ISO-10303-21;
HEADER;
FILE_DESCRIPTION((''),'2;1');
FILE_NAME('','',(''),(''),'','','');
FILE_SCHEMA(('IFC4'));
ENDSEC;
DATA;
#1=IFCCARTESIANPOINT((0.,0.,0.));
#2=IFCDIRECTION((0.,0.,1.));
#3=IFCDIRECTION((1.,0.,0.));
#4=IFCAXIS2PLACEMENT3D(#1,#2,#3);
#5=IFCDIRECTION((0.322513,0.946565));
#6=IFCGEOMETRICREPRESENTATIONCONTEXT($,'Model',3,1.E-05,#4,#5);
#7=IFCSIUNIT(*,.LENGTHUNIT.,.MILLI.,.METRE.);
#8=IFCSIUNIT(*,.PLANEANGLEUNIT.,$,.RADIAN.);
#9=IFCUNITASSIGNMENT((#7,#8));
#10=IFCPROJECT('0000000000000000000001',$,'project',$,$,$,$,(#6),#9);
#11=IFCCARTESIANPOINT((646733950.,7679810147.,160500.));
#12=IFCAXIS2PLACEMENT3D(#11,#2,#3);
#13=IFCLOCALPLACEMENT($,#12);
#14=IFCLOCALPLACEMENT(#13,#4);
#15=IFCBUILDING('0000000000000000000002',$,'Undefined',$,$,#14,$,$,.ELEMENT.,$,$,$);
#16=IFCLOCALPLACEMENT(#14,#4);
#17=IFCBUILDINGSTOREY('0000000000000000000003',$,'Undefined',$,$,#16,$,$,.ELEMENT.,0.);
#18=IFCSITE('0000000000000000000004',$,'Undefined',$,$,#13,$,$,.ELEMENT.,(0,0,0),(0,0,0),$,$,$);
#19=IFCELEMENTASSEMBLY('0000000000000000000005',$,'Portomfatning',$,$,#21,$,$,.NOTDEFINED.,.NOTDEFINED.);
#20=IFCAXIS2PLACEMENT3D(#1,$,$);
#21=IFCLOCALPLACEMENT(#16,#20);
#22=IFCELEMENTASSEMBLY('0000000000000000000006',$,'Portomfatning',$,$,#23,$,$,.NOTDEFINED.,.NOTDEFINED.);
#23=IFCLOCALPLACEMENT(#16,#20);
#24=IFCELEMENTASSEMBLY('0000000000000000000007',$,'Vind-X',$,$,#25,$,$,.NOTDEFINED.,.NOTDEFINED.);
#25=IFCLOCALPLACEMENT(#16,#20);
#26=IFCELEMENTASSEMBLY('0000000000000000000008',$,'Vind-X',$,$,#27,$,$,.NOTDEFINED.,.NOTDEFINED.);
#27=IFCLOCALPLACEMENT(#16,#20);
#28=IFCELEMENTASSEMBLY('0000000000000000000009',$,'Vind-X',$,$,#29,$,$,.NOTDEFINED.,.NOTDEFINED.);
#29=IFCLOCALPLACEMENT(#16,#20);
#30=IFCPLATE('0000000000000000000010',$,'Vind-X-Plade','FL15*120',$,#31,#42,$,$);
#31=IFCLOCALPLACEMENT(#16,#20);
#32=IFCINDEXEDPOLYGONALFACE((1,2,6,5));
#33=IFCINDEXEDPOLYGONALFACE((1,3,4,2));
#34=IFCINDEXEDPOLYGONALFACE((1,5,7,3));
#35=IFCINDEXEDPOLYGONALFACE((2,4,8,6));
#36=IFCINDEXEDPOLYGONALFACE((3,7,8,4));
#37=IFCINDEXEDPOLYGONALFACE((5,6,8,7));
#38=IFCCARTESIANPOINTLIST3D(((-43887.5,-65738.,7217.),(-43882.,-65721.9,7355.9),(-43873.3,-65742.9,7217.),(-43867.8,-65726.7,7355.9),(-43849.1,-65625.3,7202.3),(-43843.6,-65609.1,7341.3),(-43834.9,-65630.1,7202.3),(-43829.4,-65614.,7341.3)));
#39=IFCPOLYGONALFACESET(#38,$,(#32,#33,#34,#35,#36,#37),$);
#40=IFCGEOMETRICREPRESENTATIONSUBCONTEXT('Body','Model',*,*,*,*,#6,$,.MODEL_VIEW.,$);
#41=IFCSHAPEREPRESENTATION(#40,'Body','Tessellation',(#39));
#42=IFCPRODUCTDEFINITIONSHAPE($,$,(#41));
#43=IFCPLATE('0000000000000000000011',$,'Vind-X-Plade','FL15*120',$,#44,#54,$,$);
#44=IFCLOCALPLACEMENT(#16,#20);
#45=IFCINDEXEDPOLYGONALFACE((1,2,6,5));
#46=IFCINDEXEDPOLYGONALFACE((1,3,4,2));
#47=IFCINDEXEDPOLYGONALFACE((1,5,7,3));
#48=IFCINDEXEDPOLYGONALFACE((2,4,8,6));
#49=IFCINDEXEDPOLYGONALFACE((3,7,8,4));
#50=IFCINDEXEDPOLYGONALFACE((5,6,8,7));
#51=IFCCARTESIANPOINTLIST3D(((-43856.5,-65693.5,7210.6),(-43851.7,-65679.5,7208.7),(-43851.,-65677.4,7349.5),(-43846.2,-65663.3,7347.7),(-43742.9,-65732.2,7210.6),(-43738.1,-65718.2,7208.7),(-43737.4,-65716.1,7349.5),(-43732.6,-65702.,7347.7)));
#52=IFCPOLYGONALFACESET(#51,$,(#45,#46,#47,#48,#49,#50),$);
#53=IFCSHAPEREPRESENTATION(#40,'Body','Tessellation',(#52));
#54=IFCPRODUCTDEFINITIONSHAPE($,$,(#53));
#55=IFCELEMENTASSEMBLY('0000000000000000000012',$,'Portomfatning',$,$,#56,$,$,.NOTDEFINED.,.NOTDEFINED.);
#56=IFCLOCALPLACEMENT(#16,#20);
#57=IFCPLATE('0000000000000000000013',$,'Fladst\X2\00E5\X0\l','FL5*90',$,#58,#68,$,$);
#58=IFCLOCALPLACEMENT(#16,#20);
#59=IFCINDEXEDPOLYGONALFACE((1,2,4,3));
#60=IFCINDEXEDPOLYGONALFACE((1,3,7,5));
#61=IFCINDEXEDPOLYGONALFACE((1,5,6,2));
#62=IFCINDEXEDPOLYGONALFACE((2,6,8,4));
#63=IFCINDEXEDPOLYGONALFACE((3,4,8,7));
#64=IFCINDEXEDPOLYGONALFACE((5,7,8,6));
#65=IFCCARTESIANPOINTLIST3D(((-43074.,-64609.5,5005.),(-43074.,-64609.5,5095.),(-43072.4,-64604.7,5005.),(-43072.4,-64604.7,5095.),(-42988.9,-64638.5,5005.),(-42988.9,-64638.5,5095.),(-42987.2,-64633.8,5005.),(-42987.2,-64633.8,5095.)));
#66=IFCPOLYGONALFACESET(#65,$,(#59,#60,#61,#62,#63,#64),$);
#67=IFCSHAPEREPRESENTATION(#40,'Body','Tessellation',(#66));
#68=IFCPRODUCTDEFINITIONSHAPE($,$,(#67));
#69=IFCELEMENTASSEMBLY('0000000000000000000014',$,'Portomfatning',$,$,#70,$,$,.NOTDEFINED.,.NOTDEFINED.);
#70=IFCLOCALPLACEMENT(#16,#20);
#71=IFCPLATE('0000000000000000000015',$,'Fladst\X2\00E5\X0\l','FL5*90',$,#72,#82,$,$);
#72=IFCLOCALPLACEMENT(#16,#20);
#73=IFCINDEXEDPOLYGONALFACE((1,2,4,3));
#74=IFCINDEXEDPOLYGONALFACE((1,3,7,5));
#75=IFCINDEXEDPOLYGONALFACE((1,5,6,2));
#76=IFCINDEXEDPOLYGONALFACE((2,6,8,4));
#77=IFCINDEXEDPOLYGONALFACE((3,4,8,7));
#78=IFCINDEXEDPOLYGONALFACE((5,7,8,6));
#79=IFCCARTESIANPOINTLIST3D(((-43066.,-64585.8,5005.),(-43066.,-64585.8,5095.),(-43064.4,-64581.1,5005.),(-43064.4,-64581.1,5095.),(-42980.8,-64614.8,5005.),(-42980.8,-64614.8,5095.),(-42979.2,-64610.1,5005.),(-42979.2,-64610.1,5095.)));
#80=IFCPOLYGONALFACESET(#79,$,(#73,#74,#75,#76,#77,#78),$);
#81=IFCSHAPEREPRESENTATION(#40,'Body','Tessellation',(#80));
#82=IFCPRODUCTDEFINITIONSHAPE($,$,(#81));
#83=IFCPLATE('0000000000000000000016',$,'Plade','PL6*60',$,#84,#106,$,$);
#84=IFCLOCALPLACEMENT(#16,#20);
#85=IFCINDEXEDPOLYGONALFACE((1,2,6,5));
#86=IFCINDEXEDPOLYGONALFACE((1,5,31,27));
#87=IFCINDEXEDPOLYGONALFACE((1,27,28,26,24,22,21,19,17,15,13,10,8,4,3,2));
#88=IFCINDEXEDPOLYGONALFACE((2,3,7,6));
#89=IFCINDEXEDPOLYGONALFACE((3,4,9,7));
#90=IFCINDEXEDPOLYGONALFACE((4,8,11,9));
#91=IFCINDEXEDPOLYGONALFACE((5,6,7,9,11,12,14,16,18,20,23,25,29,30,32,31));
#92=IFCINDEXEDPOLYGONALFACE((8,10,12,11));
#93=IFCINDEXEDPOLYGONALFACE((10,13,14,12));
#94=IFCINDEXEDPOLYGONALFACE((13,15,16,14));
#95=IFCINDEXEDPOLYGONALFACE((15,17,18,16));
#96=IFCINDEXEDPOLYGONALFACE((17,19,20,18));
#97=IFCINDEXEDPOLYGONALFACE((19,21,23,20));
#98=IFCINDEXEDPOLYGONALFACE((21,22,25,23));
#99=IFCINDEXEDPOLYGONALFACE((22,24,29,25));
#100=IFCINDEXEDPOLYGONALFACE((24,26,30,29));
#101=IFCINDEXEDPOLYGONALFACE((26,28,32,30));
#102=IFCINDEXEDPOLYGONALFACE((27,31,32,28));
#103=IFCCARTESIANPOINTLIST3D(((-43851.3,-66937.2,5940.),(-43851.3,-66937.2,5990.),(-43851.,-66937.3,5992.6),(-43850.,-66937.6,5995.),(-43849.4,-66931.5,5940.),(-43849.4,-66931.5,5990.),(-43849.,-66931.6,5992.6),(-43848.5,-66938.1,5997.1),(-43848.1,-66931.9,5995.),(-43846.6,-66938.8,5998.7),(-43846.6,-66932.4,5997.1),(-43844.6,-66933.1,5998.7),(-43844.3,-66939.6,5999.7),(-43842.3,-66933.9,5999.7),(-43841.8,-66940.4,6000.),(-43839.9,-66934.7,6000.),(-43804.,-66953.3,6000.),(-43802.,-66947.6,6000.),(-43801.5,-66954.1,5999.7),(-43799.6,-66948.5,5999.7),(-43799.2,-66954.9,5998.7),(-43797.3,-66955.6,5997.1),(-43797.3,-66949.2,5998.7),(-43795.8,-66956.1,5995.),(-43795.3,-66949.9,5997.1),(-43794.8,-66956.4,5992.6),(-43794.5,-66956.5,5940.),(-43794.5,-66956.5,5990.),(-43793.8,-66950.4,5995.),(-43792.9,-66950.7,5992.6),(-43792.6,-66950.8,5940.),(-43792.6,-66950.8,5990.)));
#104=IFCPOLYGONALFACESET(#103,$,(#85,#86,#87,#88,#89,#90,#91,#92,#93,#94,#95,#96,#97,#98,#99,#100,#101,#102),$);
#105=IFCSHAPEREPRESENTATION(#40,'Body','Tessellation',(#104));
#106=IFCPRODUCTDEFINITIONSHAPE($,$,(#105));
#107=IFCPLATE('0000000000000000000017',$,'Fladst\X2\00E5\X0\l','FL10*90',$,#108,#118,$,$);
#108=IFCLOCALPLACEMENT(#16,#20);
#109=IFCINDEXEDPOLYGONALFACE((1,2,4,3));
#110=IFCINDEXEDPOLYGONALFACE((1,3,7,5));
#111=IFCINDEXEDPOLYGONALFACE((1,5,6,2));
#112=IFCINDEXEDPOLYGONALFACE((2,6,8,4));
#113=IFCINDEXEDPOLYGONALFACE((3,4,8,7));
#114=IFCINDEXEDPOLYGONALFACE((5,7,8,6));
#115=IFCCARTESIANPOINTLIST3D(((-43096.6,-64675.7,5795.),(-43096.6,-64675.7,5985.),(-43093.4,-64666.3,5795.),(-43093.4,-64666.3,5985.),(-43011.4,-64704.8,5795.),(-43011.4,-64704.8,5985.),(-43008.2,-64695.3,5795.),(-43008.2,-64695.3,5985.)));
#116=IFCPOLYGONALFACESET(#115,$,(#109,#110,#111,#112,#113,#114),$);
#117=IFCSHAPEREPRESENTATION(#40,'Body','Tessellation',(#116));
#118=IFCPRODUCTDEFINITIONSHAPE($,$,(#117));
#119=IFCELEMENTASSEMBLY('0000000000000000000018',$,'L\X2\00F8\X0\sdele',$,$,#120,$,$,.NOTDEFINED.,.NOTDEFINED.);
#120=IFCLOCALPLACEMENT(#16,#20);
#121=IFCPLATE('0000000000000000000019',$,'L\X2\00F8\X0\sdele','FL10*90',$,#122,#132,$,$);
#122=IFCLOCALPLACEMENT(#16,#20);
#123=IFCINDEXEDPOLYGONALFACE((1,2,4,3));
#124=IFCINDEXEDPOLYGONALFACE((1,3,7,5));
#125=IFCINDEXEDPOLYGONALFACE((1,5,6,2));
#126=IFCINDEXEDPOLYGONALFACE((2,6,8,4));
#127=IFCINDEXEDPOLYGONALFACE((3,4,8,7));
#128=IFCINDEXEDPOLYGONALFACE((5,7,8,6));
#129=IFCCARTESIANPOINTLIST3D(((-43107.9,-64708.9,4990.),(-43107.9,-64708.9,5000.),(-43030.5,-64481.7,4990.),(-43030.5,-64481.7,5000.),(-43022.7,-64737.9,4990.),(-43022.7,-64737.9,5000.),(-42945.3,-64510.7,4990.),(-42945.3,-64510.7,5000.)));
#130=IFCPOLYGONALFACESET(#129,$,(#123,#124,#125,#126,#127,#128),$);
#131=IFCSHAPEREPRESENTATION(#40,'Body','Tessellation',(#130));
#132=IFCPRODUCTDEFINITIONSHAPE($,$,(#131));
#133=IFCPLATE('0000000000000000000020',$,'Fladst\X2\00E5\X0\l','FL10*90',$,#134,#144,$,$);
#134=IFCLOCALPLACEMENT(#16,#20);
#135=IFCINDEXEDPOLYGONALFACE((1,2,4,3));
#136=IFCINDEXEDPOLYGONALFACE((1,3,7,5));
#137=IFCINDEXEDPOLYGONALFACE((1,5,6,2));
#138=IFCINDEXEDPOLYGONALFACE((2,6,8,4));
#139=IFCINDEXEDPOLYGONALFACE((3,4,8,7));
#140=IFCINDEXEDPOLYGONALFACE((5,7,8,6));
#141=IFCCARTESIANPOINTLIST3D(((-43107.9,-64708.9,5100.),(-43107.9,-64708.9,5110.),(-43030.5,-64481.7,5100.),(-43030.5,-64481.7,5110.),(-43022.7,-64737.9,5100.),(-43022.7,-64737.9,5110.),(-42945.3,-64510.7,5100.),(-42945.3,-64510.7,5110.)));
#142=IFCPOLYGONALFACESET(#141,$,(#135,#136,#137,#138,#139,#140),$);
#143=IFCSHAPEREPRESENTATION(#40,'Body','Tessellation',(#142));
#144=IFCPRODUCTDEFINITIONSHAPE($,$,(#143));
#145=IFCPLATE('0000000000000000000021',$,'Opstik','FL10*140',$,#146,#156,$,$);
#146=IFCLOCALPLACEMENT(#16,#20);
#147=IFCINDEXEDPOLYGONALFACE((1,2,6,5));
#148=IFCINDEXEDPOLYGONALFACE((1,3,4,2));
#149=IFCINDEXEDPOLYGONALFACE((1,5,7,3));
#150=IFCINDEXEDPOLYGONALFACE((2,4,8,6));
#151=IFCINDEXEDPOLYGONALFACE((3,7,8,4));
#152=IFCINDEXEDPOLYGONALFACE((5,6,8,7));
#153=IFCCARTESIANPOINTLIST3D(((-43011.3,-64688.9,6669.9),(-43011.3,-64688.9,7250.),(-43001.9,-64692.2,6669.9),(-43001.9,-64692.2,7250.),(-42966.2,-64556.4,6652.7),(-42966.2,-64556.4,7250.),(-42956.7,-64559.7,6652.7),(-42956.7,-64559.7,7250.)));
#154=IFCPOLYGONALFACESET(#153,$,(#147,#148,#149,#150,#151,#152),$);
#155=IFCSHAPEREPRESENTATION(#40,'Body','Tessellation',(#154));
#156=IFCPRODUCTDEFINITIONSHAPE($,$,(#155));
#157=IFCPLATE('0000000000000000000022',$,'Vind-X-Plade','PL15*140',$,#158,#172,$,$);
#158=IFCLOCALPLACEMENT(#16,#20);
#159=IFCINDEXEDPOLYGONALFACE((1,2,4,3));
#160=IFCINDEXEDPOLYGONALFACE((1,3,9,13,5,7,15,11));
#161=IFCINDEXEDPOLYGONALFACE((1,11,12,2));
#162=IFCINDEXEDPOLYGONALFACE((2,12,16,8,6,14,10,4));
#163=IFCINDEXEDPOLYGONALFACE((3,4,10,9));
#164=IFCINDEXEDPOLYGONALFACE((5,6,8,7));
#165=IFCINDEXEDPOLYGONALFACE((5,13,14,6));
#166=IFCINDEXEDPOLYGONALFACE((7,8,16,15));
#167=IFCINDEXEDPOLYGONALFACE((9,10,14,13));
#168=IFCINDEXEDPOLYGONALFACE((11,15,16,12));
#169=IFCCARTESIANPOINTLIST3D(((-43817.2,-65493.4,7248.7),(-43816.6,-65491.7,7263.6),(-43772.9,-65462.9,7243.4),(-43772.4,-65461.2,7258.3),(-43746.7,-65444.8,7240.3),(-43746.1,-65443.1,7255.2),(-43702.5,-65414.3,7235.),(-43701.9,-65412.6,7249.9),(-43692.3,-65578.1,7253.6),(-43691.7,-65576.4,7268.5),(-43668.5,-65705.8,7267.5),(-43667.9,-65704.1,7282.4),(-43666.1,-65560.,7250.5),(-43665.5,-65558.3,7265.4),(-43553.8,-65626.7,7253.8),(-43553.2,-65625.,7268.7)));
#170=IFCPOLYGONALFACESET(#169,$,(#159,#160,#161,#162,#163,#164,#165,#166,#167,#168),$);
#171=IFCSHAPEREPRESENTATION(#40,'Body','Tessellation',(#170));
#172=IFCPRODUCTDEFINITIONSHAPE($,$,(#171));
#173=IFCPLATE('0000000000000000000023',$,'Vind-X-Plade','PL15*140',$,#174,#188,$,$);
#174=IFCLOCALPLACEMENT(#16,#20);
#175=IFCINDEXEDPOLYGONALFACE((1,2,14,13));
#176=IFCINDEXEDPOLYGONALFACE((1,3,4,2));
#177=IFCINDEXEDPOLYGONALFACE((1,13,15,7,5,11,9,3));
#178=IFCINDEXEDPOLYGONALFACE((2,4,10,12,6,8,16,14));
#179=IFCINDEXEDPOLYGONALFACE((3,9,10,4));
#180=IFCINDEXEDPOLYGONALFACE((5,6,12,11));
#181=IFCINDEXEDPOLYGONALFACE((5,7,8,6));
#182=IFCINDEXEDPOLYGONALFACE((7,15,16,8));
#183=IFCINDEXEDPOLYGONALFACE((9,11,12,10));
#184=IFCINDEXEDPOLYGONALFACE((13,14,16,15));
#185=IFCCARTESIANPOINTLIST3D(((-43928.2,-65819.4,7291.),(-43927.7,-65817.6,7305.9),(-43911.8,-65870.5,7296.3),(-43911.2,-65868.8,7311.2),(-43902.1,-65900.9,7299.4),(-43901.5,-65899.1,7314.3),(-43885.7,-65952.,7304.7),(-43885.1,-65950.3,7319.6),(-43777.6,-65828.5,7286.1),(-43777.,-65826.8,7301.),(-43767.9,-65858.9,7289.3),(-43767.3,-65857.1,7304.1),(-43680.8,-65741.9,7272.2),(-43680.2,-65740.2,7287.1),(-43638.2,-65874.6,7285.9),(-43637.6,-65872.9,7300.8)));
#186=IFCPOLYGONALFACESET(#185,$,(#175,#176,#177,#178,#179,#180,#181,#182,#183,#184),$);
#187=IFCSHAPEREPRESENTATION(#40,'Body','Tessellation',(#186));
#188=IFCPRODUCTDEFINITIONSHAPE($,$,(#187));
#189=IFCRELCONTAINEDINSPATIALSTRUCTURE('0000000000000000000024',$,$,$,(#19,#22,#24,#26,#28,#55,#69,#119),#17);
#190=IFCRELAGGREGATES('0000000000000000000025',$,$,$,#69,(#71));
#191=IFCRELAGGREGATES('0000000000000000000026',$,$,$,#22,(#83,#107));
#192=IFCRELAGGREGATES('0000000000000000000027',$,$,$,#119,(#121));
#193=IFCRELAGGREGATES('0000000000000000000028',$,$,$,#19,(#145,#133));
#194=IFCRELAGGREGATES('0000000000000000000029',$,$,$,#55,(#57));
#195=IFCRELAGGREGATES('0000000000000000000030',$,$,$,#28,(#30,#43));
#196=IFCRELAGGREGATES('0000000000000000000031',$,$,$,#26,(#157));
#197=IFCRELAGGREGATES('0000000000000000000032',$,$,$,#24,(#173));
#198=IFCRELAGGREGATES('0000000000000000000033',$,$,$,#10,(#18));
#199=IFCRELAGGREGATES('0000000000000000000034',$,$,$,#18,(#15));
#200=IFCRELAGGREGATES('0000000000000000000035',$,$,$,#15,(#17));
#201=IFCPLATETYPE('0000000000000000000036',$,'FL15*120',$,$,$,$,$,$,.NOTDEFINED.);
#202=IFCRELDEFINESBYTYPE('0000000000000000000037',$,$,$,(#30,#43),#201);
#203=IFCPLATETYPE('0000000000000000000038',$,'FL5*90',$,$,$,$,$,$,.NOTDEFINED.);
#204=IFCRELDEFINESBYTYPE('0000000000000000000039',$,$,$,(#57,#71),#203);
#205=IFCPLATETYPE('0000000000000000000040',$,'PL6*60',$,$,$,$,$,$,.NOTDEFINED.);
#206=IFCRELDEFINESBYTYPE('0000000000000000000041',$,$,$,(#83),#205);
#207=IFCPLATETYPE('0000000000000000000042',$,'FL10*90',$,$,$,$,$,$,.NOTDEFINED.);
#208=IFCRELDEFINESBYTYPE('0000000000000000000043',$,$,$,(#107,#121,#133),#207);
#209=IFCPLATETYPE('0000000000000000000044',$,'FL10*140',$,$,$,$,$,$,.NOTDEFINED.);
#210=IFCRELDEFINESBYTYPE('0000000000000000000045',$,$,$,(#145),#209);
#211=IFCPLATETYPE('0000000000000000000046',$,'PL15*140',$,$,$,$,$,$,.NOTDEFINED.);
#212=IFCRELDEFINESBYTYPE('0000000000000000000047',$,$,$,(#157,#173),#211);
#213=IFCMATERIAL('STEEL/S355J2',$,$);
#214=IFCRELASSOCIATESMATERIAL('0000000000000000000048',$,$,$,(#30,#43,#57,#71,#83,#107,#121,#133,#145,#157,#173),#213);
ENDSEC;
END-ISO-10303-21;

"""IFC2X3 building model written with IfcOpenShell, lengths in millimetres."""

from ifc_helpers import new_model, si_unit, direction, frame, frame_2d, origin_with_axes, place, context, subcontext, project, spatial, polyline, circle_curve, parameter, trimmed, segment, composite_curve, outline, extrude, material, type_object, element, aggregate, save


model = new_model("IFC2X3")

# Units and contexts
model_context = context("Model", 3, precision=1e-05, world=origin_with_axes(), true_north=direction((0.322513, 0.946565)))
body_context = subcontext(model_context, "Body", "Model", "MODEL_VIEW")
ifc_project = project(units=[si_unit("LENGTHUNIT", "METRE", prefix="MILLI"), si_unit("PLANEANGLEUNIT", "RADIAN")], contexts=[model_context])

# Site, building, storey
site_placement = place(None, frame((646733950.0, 7679810147.0, 160500.0), z_axis=(0.0, 0.0, 1.0), x_axis=(1.0, 0.0, 0.0)))
site = spatial("IfcSite", under=ifc_project, at=site_placement, Name="Undefined", CompositionType="ELEMENT", RefLatitude=(0, 0, 0), RefLongitude=(0, 0, 0))
building_placement = place(site_placement, origin_with_axes())
building = spatial("IfcBuilding", under=site, at=building_placement, Name="Undefined", CompositionType="ELEMENT")
storey_placement = place(building_placement, origin_with_axes())
storey = spatial("IfcBuildingStorey", under=building, at=storey_placement, Name="Undefined", CompositionType="ELEMENT", Elevation=0.0)

# Element assembly
assembly_1_placement = place(storey_placement, origin_with_axes())
assembly_1 = element("IfcElementAssembly", 1, at=assembly_1_placement, inside=storey, Name="Portomfatning", AssemblyPlace="NOTDEFINED", PredefinedType="NOTDEFINED")

# Element assemblies
assembly_2_placement = place(storey_placement, origin_with_axes())
assembly_2 = element("IfcElementAssembly", 2, at=assembly_2_placement, inside=storey, Name="Portomfatning", AssemblyPlace="NOTDEFINED", PredefinedType="NOTDEFINED")
assembly_3_placement = place(storey_placement, origin_with_axes())
assembly_3 = element("IfcElementAssembly", 3, at=assembly_3_placement, inside=storey, Name="Vind-X", AssemblyPlace="NOTDEFINED", PredefinedType="NOTDEFINED")
ifc_material_1 = material(Name="STEEL/S355J2")
assembly_4_placement = place(storey_placement, origin_with_axes())
assembly_4 = element("IfcElementAssembly", 4, at=assembly_4_placement, inside=storey, Name="Vind-X", AssemblyPlace="NOTDEFINED", PredefinedType="NOTDEFINED")

# Element assembly, plates
assembly_5_placement = place(storey_placement, origin_with_axes())
assembly_5 = element("IfcElementAssembly", 5, at=assembly_5_placement, inside=storey, Name="Vind-X", AssemblyPlace="NOTDEFINED", PredefinedType="NOTDEFINED")
plate_type_1 = type_object("IfcPlateType", Name="FL15*120", PredefinedType="NOTDEFINED")
plate_1_placement = place(assembly_5_placement, frame((-43842.0, -65627.7, 7202.3), z_axis=(0.946565, -0.322513, 0.0), x_axis=(0.039304, 0.115357, 0.992546)))
plate_1 = element("IfcPlate", 6, at=plate_1_placement, type_object=plate_type_1, material=ifc_material_1, Name="Vind-X-Plade", Description="FL15*120", context=body_context, shape_type="SweptSolid", body=[
    extrude(outline(polyline([(0.0, 0.0), (140.0, 0.0), (140.0, 120.0), (0.0, 120.0), (0.0, 0.0)])), frame((0.0, 0.0, -7.5), z_axis=(0.0, 0.0, 1.0), x_axis=(1.0, 0.0, 0.0)), (0.0, 0.0, 1.0), 15.0),
])
plate_2_placement = place(assembly_5_placement, frame((-43737.7, -65717.1, 7279.1), z_axis=(0.320109, 0.93951, -0.121869), x_axis=(-0.946565, 0.322513, 0.0)))
plate_2 = element("IfcPlate", 7, at=plate_2_placement, type_object=plate_type_1, material=ifc_material_1, Name="Vind-X-Plade", Description="FL15*120", context=body_context, shape_type="SweptSolid", body=[
    extrude(outline(polyline([(0.0, -70.0), (0.0, 70.0), (120.0, 70.0), (120.0, -70.0), (0.0, -70.0)])), frame((0.0, 0.0, -7.5), z_axis=(0.0, 0.0, 1.0), x_axis=(1.0, 0.0, 0.0)), (0.0, 0.0, 1.0), 15.0),
])

# Element assemblies, plates
assembly_6_placement = place(storey_placement, origin_with_axes())
assembly_6 = element("IfcElementAssembly", 8, at=assembly_6_placement, inside=storey, Name="Portomfatning", AssemblyPlace="NOTDEFINED", PredefinedType="NOTDEFINED")
plate_type_2 = type_object("IfcPlateType", Name="FL5*90", PredefinedType="NOTDEFINED")
plate_3_placement = place(assembly_6_placement, frame((-42988.0, -64636.1, 5050.0), z_axis=(-0.322513, -0.946565, 0.0), x_axis=(-0.946565, 0.322513, 0.0)))
plate_3 = element("IfcPlate", 9, at=plate_3_placement, type_object=plate_type_2, material=ifc_material_1, Name="Fladstål", Description="FL5*90", context=body_context, shape_type="SweptSolid", body=[
    extrude(outline(polyline([(0.0, -45.0), (0.0, 45.0), (90.0, 45.0), (90.0, -45.0), (0.0, -45.0)])), frame((0.0, 0.0, -2.5), z_axis=(0.0, 0.0, 1.0), x_axis=(1.0, 0.0, 0.0)), (0.0, 0.0, 1.0), 5.0),
])
assembly_7_placement = place(storey_placement, origin_with_axes())
assembly_7 = element("IfcElementAssembly", 10, at=assembly_7_placement, inside=storey, Name="Portomfatning", AssemblyPlace="NOTDEFINED", PredefinedType="NOTDEFINED")
plate_4_placement = place(assembly_7_placement, frame((-42980.0, -64612.5, 5050.0), z_axis=(0.322513, 0.946565, 0.0), x_axis=(-0.946565, 0.322513, 0.0)))
plate_4 = element("IfcPlate", 11, at=plate_4_placement, type_object=plate_type_2, material=ifc_material_1, Name="Fladstål", Description="FL5*90", context=body_context, shape_type="SweptSolid", body=[
    extrude(outline(polyline([(0.0, -45.0), (0.0, 45.0), (90.0, 45.0), (90.0, -45.0), (0.0, -45.0)])), frame((0.0, 0.0, -2.5), z_axis=(0.0, 0.0, 1.0), x_axis=(1.0, 0.0, 0.0)), (0.0, 0.0, 1.0), 5.0),
])
aggregate(assembly_7, [plate_4])

# Plates
plate_type_3 = type_object("IfcPlateType", Name="PL6*60", PredefinedType="NOTDEFINED")
plate_5_placement = place(assembly_2_placement, frame((-43850.3, -66934.3, 5940.0), z_axis=(-0.322514, -0.946565, 0.0), x_axis=(0.946565, -0.322514, 0.0)))
plate_5 = element("IfcPlate", 12, at=plate_5_placement, type_object=plate_type_3, material=ifc_material_1, Name="Plade", Description="PL6*60", context=body_context, shape_type="SweptSolid", body=[
    extrude(outline(composite_curve([segment(polyline([(0.0, 0.0), (60.0, 0.0), (60.0, 50.0)]), True, "CONTINUOUS"), segment(trimmed(circle_curve(frame_2d((50.0, 50.0), x_axis=(1.0, 0.0)), 10.0), [parameter(0.0)], [parameter(1.570796)], True, "PARAMETER"), True, "CONTINUOUS"), segment(polyline([(50.0, 60.0), (10.0, 60.0)]), True, "CONTINUOUS"), segment(trimmed(circle_curve(frame_2d((10.0, 50.0), x_axis=(0.0, 1.0)), 10.0), [parameter(0.0)], [parameter(1.570796)], True, "PARAMETER"), True, "CONTINUOUS"), segment(polyline([(0.0, 50.0), (0.0, 0.0)]), True, "CONTINUOUS")], self_intersect=True)), frame((0.0, 0.0, -3.0), z_axis=(0.0, 0.0, 1.0), x_axis=(1.0, 0.0, 0.0)), (0.0, 0.0, 1.0), 6.0),
])
plate_type_4 = type_object("IfcPlateType", Name="FL10*90", PredefinedType="NOTDEFINED")
plate_6_placement = place(assembly_2_placement, frame((-43052.4, -64685.5, 5795.0), z_axis=(-0.322513, -0.946565, 0.0), x_axis=(0.0, 0.0, 1.0)))
plate_6 = element("IfcPlate", 13, at=plate_6_placement, type_object=plate_type_4, material=ifc_material_1, Name="Fladstål", Description="FL10*90", context=body_context, shape_type="SweptSolid", body=[
    extrude(outline(polyline([(0.0, -45.0), (0.0, 45.0), (190.0, 45.0), (190.0, -45.0), (0.0, -45.0)])), frame((0.0, 0.0, -5.0), z_axis=(0.0, 0.0, 1.0), x_axis=(1.0, 0.0, 0.0)), (0.0, 0.0, 1.0), 10.0),
])
aggregate(assembly_2, [plate_5, plate_6])

# Element assembly, plate
assembly_8_placement = place(storey_placement, origin_with_axes())
assembly_8 = element("IfcElementAssembly", 14, at=assembly_8_placement, inside=storey, Name="Løsdele", AssemblyPlace="NOTDEFINED", PredefinedType="NOTDEFINED")
plate_7_placement = place(assembly_8_placement, frame((-43065.3, -64723.4, 4995.0), z_axis=(0.0, 0.0, -1.0), x_axis=(0.322513, 0.946565, 0.0)))
plate_7 = element("IfcPlate", 15, at=plate_7_placement, type_object=plate_type_4, material=ifc_material_1, Name="Løsdele", Description="FL10*90", context=body_context, shape_type="SweptSolid", body=[
    extrude(outline(polyline([(0.0, -45.0), (0.0, 45.0), (240.0, 45.0), (240.0, -45.0), (0.0, -45.0)])), frame((0.0, 0.0, -5.0), z_axis=(0.0, 0.0, 1.0), x_axis=(1.0, 0.0, 0.0)), (0.0, 0.0, 1.0), 10.0),
])
aggregate(assembly_8, [plate_7])

# Plates
plate_8_placement = place(assembly_1_placement, frame((-43065.3, -64723.4, 5105.0), z_axis=(0.0, 0.0, -1.0), x_axis=(0.322513, 0.946565, 0.0)))
plate_8 = element("IfcPlate", 16, at=plate_8_placement, type_object=plate_type_4, material=ifc_material_1, Name="Fladstål", Description="FL10*90", context=body_context, shape_type="SweptSolid", body=[
    extrude(outline(polyline([(0.0, -45.0), (0.0, 45.0), (240.0, 45.0), (240.0, -45.0), (0.0, -45.0)])), frame((0.0, 0.0, -5.0), z_axis=(0.0, 0.0, 1.0), x_axis=(1.0, 0.0, 0.0)), (0.0, 0.0, 1.0), 10.0),
])
plate_type_5 = type_object("IfcPlateType", Name="FL10*140", PredefinedType="NOTDEFINED")
plate_9_placement = place(assembly_1_placement, frame((-43006.6, -64690.6, 6669.9), z_axis=(-0.946565, 0.322513, 0.0), x_axis=(0.0, 0.0, 1.0)))
plate_9 = element("IfcPlate", 17, at=plate_9_placement, type_object=plate_type_5, material=ifc_material_1, Name="Opstik", Description="FL10*140", context=body_context, shape_type="SweptSolid", body=[
    extrude(outline(polyline([(0.0, 0.0), (580.1, 0.0), (580.1, 0.0), (580.1, 140.0), (580.1, 140.0), (-17.2, 140.0), (0.0, 0.0)])), frame((0.0, 0.0, -5.0), z_axis=(0.0, 0.0, 1.0), x_axis=(1.0, 0.0, 0.0)), (0.0, 0.0, 1.0), 10.0),
])
plate_type_6 = type_object("IfcPlateType", Name="PL15*140", PredefinedType="NOTDEFINED")
plate_10_placement = place(assembly_4_placement, frame((-43816.9, -65492.5, 7256.2), z_axis=(0.039304, 0.115357, 0.992546), x_axis=(0.572042, -0.817031, 0.072306)))
plate_10 = element("IfcPlate", 18, at=plate_10_placement, type_object=plate_type_6, material=ifc_material_1, Name="Vind-X-Plade", Description="PL15*140", context=body_context, shape_type="SweptSolid", body=[
    extrude(outline(polyline([(0.0, 0.0), (260.0, 0.0), (260.0, 140.0), (0.0, 140.0), (0.0, 86.0), (141.0, 86.0), (141.0, 54.0), (0.0, 54.0), (0.0, 0.0)])), frame((0.0, 0.0, -7.5), z_axis=(0.0, 0.0, 1.0), x_axis=(1.0, 0.0, 0.0)), (0.0, 0.0, 1.0), 15.0),
])
plate_11_placement = place(assembly_3_placement, frame((-43885.4, -65951.2, 7312.2), z_axis=(0.039304, 0.115357, 0.992546), x_axis=(0.951886, 0.297802, -0.072306)))
plate_11 = element("IfcPlate", 19, at=plate_11_placement, type_object=plate_type_6, material=ifc_material_1, Name="Vind-X-Plade", Description="PL15*140", context=body_context, shape_type="SweptSolid", body=[
    extrude(outline(polyline([(0.0, 0.0), (260.0, 0.0), (260.0, 140.0), (0.0, 140.0), (0.0, 86.0), (141.0, 86.0), (141.0, 54.0), (0.0, 54.0), (0.0, 0.0)])), frame((0.0, 0.0, -7.5), z_axis=(0.0, 0.0, 1.0), x_axis=(1.0, 0.0, 0.0)), (0.0, 0.0, 1.0), 15.0),
])

aggregate(assembly_1, [plate_9, plate_8])
aggregate(assembly_6, [plate_3])
aggregate(assembly_5, [plate_1, plate_2])
aggregate(assembly_4, [plate_10])
aggregate(assembly_3, [plate_11])

save(model, "model.ifc")
